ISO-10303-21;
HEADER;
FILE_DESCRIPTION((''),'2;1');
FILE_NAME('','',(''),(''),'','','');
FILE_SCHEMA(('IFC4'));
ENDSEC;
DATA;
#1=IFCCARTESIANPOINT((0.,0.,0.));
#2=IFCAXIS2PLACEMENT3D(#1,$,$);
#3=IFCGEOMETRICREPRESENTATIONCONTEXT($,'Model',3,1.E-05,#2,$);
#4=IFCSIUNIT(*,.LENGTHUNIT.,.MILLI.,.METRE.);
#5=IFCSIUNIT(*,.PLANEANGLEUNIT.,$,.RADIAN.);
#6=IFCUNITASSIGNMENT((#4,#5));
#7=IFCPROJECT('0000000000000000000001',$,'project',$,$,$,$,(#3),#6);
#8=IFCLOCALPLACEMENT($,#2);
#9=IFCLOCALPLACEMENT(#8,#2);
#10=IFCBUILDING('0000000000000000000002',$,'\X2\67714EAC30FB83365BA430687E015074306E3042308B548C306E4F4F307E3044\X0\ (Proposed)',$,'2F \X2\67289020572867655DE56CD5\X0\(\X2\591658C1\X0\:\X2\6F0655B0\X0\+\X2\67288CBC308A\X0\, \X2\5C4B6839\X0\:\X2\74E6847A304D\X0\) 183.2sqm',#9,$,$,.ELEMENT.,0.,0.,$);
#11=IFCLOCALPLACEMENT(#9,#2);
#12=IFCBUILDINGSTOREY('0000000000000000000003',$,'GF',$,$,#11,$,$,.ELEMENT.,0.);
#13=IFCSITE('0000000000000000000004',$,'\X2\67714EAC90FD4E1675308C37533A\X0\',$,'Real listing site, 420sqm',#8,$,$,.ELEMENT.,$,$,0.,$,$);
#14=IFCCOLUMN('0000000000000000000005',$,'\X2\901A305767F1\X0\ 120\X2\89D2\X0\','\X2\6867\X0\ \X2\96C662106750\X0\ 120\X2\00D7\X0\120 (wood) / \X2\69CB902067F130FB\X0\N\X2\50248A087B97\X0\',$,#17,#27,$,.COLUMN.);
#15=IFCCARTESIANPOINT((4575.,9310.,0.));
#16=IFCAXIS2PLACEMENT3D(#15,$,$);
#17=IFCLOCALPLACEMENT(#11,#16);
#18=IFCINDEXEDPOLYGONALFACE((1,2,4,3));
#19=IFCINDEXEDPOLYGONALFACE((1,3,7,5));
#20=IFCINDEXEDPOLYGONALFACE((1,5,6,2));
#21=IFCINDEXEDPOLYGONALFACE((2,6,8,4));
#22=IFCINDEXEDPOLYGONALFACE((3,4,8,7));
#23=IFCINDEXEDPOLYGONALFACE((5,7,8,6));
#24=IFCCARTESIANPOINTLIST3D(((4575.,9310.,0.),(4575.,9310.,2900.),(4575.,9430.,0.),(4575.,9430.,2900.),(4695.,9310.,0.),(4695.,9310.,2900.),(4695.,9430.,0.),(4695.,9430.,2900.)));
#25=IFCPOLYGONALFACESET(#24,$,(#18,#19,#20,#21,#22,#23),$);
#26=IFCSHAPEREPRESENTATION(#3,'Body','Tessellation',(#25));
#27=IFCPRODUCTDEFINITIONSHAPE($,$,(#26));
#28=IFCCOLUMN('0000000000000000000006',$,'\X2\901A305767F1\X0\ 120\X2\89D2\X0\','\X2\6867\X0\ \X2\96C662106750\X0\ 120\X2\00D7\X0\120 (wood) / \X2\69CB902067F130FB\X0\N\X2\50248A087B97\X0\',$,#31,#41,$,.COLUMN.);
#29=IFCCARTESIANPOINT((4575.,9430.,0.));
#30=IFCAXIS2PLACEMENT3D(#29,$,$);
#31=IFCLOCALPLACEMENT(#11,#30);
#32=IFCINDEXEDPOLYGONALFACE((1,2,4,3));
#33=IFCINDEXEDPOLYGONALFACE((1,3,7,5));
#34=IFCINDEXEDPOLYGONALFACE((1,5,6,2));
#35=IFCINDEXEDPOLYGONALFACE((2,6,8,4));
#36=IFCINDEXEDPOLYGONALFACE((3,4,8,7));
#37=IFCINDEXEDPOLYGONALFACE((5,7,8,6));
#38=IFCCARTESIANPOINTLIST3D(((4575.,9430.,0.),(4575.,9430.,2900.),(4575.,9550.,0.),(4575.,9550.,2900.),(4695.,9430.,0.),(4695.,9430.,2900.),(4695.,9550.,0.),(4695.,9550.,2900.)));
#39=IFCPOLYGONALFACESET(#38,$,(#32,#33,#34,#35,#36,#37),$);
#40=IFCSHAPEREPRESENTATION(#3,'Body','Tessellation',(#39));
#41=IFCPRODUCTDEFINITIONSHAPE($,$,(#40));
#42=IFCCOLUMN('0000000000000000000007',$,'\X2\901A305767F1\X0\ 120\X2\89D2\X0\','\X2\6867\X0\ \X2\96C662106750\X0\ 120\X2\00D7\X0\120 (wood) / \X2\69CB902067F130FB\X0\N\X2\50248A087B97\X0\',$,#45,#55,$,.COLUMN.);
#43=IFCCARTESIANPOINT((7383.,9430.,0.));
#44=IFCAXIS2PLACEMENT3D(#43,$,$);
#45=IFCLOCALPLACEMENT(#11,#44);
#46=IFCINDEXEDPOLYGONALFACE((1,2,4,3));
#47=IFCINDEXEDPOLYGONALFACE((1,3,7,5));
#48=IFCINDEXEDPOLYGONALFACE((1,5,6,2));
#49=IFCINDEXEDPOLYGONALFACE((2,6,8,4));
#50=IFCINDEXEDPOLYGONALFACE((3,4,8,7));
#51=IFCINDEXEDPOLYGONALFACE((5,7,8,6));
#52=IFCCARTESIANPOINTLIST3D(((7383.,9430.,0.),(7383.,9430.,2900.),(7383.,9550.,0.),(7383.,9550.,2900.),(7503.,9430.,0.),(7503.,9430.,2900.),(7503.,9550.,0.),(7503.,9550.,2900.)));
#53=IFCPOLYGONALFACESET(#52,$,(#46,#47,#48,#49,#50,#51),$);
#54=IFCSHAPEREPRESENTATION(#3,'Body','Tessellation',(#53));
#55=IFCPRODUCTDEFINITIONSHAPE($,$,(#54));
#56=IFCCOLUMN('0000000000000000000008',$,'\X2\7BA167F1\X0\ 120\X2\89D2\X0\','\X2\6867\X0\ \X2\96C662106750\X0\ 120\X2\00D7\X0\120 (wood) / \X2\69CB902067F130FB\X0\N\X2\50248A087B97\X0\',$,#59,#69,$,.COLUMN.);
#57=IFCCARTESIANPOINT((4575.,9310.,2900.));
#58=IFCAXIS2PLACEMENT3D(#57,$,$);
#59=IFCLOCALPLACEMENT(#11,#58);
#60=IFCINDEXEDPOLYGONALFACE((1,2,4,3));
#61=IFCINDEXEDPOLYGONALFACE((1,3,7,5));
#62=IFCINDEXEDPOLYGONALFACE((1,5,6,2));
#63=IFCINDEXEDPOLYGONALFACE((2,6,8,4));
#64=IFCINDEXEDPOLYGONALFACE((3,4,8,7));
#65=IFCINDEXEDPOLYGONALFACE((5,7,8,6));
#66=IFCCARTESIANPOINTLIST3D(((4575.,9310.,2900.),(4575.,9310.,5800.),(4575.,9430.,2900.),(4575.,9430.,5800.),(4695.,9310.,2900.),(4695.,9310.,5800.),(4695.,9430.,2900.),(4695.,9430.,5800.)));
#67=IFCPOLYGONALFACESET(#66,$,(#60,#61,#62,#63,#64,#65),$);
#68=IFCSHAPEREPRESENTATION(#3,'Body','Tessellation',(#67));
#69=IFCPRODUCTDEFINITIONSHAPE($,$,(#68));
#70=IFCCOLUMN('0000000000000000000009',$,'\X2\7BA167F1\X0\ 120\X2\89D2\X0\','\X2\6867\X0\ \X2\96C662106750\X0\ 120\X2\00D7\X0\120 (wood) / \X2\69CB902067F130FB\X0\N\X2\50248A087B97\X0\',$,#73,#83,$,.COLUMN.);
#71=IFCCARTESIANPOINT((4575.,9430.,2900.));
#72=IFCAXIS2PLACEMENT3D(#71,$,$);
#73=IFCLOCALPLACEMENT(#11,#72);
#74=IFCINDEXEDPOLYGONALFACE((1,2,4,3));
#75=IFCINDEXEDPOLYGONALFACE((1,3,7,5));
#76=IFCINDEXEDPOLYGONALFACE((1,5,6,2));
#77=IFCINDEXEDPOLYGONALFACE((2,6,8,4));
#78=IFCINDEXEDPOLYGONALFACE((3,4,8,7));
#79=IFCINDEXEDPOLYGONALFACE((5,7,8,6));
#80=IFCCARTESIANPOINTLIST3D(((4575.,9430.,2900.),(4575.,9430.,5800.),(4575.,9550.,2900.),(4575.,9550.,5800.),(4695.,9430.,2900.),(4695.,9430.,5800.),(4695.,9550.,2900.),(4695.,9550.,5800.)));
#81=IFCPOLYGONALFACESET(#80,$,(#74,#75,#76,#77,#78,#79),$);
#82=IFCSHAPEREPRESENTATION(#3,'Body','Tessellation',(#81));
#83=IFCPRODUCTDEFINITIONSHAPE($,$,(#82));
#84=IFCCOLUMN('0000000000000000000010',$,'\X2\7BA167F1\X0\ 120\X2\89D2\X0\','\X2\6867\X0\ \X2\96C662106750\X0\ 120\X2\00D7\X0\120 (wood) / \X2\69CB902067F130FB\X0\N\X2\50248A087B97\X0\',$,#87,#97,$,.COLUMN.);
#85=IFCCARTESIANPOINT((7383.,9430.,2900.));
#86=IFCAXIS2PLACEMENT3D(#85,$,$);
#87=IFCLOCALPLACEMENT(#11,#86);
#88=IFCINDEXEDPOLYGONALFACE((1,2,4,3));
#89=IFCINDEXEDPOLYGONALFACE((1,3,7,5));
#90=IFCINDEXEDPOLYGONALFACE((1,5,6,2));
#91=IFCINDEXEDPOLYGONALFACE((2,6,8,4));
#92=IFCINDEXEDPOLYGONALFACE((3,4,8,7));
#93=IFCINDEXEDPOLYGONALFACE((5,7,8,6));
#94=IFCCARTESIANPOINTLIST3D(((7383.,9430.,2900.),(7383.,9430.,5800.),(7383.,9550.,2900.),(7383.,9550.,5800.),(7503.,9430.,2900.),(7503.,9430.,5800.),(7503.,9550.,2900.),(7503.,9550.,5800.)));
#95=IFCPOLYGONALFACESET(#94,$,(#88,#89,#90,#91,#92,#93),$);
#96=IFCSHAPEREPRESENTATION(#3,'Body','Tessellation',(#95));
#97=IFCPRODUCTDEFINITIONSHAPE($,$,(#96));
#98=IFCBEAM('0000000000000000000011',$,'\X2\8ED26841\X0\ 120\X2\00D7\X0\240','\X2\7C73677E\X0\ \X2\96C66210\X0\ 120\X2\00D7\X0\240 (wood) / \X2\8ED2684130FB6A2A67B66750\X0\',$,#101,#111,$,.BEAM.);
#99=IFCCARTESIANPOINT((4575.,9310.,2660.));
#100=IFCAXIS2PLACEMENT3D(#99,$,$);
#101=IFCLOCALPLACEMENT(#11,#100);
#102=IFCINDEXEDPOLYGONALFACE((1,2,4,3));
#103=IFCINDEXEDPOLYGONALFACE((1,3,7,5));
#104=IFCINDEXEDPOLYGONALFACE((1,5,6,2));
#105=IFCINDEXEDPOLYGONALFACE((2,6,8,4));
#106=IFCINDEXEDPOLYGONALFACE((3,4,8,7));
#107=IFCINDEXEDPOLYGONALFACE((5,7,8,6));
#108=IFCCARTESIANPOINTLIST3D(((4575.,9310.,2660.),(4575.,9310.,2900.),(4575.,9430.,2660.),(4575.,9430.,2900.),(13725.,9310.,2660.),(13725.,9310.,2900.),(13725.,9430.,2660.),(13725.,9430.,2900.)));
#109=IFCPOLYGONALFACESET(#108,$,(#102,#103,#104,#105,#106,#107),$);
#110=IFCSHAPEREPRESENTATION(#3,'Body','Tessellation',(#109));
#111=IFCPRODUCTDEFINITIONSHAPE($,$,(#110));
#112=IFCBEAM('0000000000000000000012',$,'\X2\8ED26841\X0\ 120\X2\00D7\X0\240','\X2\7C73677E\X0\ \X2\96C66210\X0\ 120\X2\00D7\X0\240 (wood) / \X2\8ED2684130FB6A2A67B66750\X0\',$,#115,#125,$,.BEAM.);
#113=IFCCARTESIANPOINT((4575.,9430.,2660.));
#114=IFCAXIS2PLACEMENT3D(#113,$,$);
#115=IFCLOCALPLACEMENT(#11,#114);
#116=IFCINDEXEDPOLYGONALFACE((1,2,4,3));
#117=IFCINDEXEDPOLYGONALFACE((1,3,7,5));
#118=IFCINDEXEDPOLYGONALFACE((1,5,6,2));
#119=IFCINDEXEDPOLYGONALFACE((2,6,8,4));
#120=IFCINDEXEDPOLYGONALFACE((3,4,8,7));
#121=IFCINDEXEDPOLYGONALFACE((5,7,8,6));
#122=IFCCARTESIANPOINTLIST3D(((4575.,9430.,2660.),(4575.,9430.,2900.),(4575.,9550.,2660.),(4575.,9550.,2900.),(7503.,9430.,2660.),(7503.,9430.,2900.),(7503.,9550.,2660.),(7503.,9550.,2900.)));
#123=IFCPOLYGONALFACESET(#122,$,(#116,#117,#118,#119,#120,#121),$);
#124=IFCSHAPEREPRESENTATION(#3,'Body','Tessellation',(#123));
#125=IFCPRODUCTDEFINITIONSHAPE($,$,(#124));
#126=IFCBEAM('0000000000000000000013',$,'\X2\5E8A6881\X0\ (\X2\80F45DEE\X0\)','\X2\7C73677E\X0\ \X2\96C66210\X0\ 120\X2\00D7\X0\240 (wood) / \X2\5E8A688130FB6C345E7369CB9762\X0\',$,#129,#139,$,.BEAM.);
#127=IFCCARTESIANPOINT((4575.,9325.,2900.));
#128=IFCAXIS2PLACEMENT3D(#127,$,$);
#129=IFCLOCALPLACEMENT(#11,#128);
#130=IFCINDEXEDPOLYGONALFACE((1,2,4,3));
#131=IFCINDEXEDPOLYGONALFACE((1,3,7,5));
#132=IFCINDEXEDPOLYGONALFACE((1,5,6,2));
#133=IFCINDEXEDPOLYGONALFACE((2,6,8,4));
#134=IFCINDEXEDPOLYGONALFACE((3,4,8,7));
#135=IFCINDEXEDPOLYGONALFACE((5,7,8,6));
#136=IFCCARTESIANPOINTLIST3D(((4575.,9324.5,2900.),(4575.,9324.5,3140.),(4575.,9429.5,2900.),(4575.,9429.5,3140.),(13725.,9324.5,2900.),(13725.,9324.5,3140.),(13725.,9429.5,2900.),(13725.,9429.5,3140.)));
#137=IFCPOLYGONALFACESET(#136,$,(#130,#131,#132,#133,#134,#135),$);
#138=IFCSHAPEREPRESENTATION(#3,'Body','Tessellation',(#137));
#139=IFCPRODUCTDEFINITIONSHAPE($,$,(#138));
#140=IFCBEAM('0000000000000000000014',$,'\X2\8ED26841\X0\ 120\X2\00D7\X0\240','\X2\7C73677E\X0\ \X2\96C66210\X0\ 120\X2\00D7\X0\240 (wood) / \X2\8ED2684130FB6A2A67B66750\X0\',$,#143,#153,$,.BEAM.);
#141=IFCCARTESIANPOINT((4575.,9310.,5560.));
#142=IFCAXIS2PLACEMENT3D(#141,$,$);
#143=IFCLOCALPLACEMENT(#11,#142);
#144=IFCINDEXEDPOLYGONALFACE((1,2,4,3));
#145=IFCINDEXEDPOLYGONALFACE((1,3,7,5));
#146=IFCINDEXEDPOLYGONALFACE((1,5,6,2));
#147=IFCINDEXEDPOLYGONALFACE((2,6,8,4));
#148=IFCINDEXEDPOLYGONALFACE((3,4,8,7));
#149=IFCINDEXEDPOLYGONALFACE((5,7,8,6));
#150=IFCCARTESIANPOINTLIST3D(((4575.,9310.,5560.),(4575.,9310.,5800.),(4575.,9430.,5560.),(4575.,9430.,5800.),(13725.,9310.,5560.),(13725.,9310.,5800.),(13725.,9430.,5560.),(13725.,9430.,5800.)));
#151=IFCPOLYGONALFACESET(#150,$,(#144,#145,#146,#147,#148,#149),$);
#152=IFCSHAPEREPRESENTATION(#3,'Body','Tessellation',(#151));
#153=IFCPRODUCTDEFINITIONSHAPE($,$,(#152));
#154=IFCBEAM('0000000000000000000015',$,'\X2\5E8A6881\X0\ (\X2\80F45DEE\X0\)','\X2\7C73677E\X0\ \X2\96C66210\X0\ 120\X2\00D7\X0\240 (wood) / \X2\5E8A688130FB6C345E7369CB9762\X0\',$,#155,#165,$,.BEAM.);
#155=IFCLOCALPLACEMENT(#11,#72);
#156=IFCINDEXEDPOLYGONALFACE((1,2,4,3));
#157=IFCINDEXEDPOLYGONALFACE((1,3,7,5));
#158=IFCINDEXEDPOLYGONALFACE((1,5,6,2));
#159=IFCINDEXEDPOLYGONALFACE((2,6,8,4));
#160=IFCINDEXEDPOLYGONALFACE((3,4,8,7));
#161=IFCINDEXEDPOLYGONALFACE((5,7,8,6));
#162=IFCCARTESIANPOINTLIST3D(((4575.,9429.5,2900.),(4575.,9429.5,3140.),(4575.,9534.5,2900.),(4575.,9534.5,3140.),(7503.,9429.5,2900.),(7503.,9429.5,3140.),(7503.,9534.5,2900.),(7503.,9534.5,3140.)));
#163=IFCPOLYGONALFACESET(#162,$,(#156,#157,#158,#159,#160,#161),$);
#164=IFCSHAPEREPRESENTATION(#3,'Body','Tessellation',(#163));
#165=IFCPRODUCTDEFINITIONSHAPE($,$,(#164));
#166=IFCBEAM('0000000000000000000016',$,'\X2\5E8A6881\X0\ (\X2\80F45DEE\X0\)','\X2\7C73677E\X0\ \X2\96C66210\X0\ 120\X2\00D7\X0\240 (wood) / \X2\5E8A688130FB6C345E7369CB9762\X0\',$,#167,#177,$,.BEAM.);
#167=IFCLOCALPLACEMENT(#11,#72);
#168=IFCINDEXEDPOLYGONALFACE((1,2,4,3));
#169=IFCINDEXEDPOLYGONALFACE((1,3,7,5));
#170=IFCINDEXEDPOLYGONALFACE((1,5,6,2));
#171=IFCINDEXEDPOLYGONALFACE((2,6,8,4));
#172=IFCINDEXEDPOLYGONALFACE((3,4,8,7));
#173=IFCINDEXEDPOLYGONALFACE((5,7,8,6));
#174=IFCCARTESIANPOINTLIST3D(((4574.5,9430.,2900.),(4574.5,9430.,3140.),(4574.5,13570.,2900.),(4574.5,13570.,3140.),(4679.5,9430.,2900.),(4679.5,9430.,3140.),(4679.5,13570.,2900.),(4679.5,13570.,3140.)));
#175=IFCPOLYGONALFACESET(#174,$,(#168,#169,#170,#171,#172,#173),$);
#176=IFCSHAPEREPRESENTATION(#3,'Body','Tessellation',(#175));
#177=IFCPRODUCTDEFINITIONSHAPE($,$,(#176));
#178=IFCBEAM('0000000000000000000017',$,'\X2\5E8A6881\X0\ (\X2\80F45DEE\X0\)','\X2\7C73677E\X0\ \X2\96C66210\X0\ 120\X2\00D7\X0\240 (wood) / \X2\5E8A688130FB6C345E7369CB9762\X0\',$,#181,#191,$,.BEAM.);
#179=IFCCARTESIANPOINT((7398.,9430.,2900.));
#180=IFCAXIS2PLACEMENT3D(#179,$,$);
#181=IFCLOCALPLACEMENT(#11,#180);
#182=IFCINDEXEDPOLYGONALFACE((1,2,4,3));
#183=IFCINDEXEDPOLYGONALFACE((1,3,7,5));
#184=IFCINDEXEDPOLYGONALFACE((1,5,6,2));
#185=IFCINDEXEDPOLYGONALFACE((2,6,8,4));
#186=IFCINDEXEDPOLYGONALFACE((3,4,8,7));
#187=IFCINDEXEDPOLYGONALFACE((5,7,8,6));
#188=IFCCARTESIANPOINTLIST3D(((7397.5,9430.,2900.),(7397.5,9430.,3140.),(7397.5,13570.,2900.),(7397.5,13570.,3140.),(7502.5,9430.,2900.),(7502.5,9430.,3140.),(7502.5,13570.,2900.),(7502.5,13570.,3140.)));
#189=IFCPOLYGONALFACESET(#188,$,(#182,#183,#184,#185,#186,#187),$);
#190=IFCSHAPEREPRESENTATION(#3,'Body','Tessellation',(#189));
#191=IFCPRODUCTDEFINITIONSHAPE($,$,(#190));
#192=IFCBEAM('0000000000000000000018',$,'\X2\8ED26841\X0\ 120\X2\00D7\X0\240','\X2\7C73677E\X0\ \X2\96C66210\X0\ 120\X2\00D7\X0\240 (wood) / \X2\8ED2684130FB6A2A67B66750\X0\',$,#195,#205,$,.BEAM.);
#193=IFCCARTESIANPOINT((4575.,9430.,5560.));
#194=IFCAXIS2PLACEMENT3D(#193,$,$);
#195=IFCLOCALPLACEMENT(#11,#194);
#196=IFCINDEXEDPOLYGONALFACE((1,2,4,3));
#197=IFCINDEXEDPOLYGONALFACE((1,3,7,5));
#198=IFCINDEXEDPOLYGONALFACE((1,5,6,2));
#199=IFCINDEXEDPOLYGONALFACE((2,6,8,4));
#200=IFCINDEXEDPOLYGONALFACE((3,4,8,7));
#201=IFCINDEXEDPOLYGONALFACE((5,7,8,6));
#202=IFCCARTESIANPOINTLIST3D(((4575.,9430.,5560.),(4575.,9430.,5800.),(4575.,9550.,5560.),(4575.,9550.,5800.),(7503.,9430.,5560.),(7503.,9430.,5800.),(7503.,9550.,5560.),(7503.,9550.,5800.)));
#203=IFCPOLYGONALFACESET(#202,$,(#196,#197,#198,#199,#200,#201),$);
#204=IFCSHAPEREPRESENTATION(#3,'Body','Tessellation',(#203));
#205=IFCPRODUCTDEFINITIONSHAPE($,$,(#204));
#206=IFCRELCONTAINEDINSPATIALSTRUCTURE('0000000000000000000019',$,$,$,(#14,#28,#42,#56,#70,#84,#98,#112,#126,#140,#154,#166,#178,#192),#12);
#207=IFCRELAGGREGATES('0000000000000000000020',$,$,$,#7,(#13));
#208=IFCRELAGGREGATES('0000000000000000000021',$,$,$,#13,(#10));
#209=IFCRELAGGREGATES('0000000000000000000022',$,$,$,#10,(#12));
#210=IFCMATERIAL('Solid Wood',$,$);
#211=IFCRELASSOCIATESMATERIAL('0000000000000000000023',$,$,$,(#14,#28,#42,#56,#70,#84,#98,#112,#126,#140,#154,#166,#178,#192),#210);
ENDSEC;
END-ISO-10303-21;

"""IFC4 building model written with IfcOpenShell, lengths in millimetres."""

from ifc_helpers import new_model, si_unit, frame, frame_2d, origin, place, context, project, spatial, rectangle, extrude, material, element, save


model = new_model("IFC4")

# Units and contexts
model_context = context("Model", 3, precision=1e-05, world=origin())
ifc_project = project(units=[si_unit("LENGTHUNIT", "METRE", prefix="MILLI"), si_unit("PLANEANGLEUNIT", "RADIAN")], contexts=[model_context])

# Site, building, storey
site_placement = place(None, origin())
site = spatial("IfcSite", under=ifc_project, at=site_placement, Name="東京都世田谷区", ObjectType="Real listing site, 420sqm", CompositionType="ELEMENT", RefElevation=0.0)
building_placement = place(site_placement, origin())
building = spatial("IfcBuilding", under=site, at=building_placement, Name="東京・茶室と縁側のある和の住まい (Proposed)", ObjectType="2F 木造在来工法(外壁:漆喰+木貼り, 屋根:瓦葺き) 183.2sqm", CompositionType="ELEMENT", ElevationOfRefHeight=0.0, ElevationOfTerrain=0.0)
storey_placement = place(building_placement, origin())
storey = spatial("IfcBuildingStorey", under=building, at=storey_placement, Name="GF", CompositionType="ELEMENT", Elevation=0.0)

# Columns
ifc_material_1 = material(Name="Solid Wood")
column_1_placement = place(storey_placement, frame((4575.0, 9310.0, 0.0)))
element("IfcColumn", 1, at=column_1_placement, inside=storey, material=ifc_material_1, Name="通し柱 120角", Description="桧 集成材 120×120 (wood) / 構造柱・N値計算", PredefinedType="COLUMN", context=model_context, shape_type="SweptSolid", body=[
    extrude(rectangle(XDim=120.0, YDim=120.0, at=frame_2d((60.0, 60.0))), frame((4575.0, 9310.0, 0.0)), (0.0, 0.0, 1.0), 2900.0),
])
column_2_placement = place(storey_placement, frame((4575.0, 9430.0, 0.0)))
element("IfcColumn", 2, at=column_2_placement, inside=storey, material=ifc_material_1, Name="通し柱 120角", Description="桧 集成材 120×120 (wood) / 構造柱・N値計算", PredefinedType="COLUMN", context=model_context, shape_type="SweptSolid", body=[
    extrude(rectangle(XDim=120.0, YDim=120.0, at=frame_2d((60.0, 60.0))), frame((4575.0, 9430.0, 0.0)), (0.0, 0.0, 1.0), 2900.0),
])
column_3_placement = place(storey_placement, frame((7383.0, 9430.0, 0.0)))
element("IfcColumn", 3, at=column_3_placement, inside=storey, material=ifc_material_1, Name="通し柱 120角", Description="桧 集成材 120×120 (wood) / 構造柱・N値計算", PredefinedType="COLUMN", context=model_context, shape_type="SweptSolid", body=[
    extrude(rectangle(XDim=120.0, YDim=120.0, at=frame_2d((60.0, 60.0))), frame((7383.0, 9430.0, 0.0)), (0.0, 0.0, 1.0), 2900.0),
])
column_4_placement = place(storey_placement, frame((4575.0, 9310.0, 2900.0)))
element("IfcColumn", 4, at=column_4_placement, inside=storey, material=ifc_material_1, Name="管柱 120角", Description="桧 集成材 120×120 (wood) / 構造柱・N値計算", PredefinedType="COLUMN", context=model_context, shape_type="SweptSolid", body=[
    extrude(rectangle(XDim=120.0, YDim=120.0, at=frame_2d((60.0, 60.0))), frame((4575.0, 9310.0, 2900.0)), (0.0, 0.0, 1.0), 2900.0),
])
column_5_placement = place(storey_placement, frame((4575.0, 9430.0, 2900.0)))
element("IfcColumn", 5, at=column_5_placement, inside=storey, material=ifc_material_1, Name="管柱 120角", Description="桧 集成材 120×120 (wood) / 構造柱・N値計算", PredefinedType="COLUMN", context=model_context, shape_type="SweptSolid", body=[
    extrude(rectangle(XDim=120.0, YDim=120.0, at=frame_2d((60.0, 60.0))), frame((4575.0, 9430.0, 2900.0)), (0.0, 0.0, 1.0), 2900.0),
])
column_6_placement = place(storey_placement, frame((7383.0, 9430.0, 2900.0)))
element("IfcColumn", 6, at=column_6_placement, inside=storey, material=ifc_material_1, Name="管柱 120角", Description="桧 集成材 120×120 (wood) / 構造柱・N値計算", PredefinedType="COLUMN", context=model_context, shape_type="SweptSolid", body=[
    extrude(rectangle(XDim=120.0, YDim=120.0, at=frame_2d((60.0, 60.0))), frame((7383.0, 9430.0, 2900.0)), (0.0, 0.0, 1.0), 2900.0),
])

# Beams
beam_1_placement = place(storey_placement, frame((4575.0, 9310.0, 2660.0)))
element("IfcBeam", 7, at=beam_1_placement, inside=storey, material=ifc_material_1, Name="軒桁 120×240", Description="米松 集成 120×240 (wood) / 軒桁・横架材", PredefinedType="BEAM", context=model_context, shape_type="SweptSolid", body=[
    extrude(rectangle(XDim=9150.0, YDim=120.0, at=frame_2d((4575.0, 60.0))), frame((4575.0, 9310.0, 2660.0)), (0.0, 0.0, 1.0), 240.0),
])
beam_2_placement = place(storey_placement, frame((4575.0, 9430.0, 2660.0)))
element("IfcBeam", 8, at=beam_2_placement, inside=storey, material=ifc_material_1, Name="軒桁 120×240", Description="米松 集成 120×240 (wood) / 軒桁・横架材", PredefinedType="BEAM", context=model_context, shape_type="SweptSolid", body=[
    extrude(rectangle(XDim=2928.0, YDim=120.0, at=frame_2d((1464.0, 60.0))), frame((4575.0, 9430.0, 2660.0)), (0.0, 0.0, 1.0), 240.0),
])
beam_3_placement = place(storey_placement, frame((4575.0, 9325.0, 2900.0)))
element("IfcBeam", 9, at=beam_3_placement, inside=storey, material=ifc_material_1, Name="床梁 (胴差)", Description="米松 集成 120×240 (wood) / 床梁・水平構面", PredefinedType="BEAM", context=model_context, shape_type="SweptSolid", body=[
    extrude(rectangle(XDim=9150.0, YDim=105.0, at=frame_2d((4575.0, 52.0))), frame((4575.0, 9325.0, 2900.0)), (0.0, 0.0, 1.0), 240.0),
])
beam_4_placement = place(storey_placement, frame((4575.0, 9310.0, 5560.0)))
element("IfcBeam", 10, at=beam_4_placement, inside=storey, material=ifc_material_1, Name="軒桁 120×240", Description="米松 集成 120×240 (wood) / 軒桁・横架材", PredefinedType="BEAM", context=model_context, shape_type="SweptSolid", body=[
    extrude(rectangle(XDim=9150.0, YDim=120.0, at=frame_2d((4575.0, 60.0))), frame((4575.0, 9310.0, 5560.0)), (0.0, 0.0, 1.0), 240.0),
])
beam_5_placement = place(storey_placement, frame((4575.0, 9430.0, 2900.0)))
element("IfcBeam", 11, at=beam_5_placement, inside=storey, material=ifc_material_1, Name="床梁 (胴差)", Description="米松 集成 120×240 (wood) / 床梁・水平構面", PredefinedType="BEAM", context=model_context, shape_type="SweptSolid", body=[
    extrude(rectangle(XDim=2928.0, YDim=105.0, at=frame_2d((1464.0, 52.0))), frame((4575.0, 9430.0, 2900.0)), (0.0, 0.0, 1.0), 240.0),
])
beam_6_placement = place(storey_placement, frame((4575.0, 9430.0, 2900.0)))
element("IfcBeam", 12, at=beam_6_placement, inside=storey, material=ifc_material_1, Name="床梁 (胴差)", Description="米松 集成 120×240 (wood) / 床梁・水平構面", PredefinedType="BEAM", context=model_context, shape_type="SweptSolid", body=[
    extrude(rectangle(XDim=105.0, YDim=4140.0, at=frame_2d((52.0, 2070.0))), frame((4575.0, 9430.0, 2900.0)), (0.0, 0.0, 1.0), 240.0),
])
beam_7_placement = place(storey_placement, frame((7398.0, 9430.0, 2900.0)))
element("IfcBeam", 13, at=beam_7_placement, inside=storey, material=ifc_material_1, Name="床梁 (胴差)", Description="米松 集成 120×240 (wood) / 床梁・水平構面", PredefinedType="BEAM", context=model_context, shape_type="SweptSolid", body=[
    extrude(rectangle(XDim=105.0, YDim=4140.0, at=frame_2d((52.0, 2070.0))), frame((7398.0, 9430.0, 2900.0)), (0.0, 0.0, 1.0), 240.0),
])
beam_8_placement = place(storey_placement, frame((4575.0, 9430.0, 5560.0)))
element("IfcBeam", 14, at=beam_8_placement, inside=storey, material=ifc_material_1, Name="軒桁 120×240", Description="米松 集成 120×240 (wood) / 軒桁・横架材", PredefinedType="BEAM", context=model_context, shape_type="SweptSolid", body=[
    extrude(rectangle(XDim=2928.0, YDim=120.0, at=frame_2d((1464.0, 60.0))), frame((4575.0, 9430.0, 5560.0)), (0.0, 0.0, 1.0), 240.0),
])

save(model, "model.ifc")
